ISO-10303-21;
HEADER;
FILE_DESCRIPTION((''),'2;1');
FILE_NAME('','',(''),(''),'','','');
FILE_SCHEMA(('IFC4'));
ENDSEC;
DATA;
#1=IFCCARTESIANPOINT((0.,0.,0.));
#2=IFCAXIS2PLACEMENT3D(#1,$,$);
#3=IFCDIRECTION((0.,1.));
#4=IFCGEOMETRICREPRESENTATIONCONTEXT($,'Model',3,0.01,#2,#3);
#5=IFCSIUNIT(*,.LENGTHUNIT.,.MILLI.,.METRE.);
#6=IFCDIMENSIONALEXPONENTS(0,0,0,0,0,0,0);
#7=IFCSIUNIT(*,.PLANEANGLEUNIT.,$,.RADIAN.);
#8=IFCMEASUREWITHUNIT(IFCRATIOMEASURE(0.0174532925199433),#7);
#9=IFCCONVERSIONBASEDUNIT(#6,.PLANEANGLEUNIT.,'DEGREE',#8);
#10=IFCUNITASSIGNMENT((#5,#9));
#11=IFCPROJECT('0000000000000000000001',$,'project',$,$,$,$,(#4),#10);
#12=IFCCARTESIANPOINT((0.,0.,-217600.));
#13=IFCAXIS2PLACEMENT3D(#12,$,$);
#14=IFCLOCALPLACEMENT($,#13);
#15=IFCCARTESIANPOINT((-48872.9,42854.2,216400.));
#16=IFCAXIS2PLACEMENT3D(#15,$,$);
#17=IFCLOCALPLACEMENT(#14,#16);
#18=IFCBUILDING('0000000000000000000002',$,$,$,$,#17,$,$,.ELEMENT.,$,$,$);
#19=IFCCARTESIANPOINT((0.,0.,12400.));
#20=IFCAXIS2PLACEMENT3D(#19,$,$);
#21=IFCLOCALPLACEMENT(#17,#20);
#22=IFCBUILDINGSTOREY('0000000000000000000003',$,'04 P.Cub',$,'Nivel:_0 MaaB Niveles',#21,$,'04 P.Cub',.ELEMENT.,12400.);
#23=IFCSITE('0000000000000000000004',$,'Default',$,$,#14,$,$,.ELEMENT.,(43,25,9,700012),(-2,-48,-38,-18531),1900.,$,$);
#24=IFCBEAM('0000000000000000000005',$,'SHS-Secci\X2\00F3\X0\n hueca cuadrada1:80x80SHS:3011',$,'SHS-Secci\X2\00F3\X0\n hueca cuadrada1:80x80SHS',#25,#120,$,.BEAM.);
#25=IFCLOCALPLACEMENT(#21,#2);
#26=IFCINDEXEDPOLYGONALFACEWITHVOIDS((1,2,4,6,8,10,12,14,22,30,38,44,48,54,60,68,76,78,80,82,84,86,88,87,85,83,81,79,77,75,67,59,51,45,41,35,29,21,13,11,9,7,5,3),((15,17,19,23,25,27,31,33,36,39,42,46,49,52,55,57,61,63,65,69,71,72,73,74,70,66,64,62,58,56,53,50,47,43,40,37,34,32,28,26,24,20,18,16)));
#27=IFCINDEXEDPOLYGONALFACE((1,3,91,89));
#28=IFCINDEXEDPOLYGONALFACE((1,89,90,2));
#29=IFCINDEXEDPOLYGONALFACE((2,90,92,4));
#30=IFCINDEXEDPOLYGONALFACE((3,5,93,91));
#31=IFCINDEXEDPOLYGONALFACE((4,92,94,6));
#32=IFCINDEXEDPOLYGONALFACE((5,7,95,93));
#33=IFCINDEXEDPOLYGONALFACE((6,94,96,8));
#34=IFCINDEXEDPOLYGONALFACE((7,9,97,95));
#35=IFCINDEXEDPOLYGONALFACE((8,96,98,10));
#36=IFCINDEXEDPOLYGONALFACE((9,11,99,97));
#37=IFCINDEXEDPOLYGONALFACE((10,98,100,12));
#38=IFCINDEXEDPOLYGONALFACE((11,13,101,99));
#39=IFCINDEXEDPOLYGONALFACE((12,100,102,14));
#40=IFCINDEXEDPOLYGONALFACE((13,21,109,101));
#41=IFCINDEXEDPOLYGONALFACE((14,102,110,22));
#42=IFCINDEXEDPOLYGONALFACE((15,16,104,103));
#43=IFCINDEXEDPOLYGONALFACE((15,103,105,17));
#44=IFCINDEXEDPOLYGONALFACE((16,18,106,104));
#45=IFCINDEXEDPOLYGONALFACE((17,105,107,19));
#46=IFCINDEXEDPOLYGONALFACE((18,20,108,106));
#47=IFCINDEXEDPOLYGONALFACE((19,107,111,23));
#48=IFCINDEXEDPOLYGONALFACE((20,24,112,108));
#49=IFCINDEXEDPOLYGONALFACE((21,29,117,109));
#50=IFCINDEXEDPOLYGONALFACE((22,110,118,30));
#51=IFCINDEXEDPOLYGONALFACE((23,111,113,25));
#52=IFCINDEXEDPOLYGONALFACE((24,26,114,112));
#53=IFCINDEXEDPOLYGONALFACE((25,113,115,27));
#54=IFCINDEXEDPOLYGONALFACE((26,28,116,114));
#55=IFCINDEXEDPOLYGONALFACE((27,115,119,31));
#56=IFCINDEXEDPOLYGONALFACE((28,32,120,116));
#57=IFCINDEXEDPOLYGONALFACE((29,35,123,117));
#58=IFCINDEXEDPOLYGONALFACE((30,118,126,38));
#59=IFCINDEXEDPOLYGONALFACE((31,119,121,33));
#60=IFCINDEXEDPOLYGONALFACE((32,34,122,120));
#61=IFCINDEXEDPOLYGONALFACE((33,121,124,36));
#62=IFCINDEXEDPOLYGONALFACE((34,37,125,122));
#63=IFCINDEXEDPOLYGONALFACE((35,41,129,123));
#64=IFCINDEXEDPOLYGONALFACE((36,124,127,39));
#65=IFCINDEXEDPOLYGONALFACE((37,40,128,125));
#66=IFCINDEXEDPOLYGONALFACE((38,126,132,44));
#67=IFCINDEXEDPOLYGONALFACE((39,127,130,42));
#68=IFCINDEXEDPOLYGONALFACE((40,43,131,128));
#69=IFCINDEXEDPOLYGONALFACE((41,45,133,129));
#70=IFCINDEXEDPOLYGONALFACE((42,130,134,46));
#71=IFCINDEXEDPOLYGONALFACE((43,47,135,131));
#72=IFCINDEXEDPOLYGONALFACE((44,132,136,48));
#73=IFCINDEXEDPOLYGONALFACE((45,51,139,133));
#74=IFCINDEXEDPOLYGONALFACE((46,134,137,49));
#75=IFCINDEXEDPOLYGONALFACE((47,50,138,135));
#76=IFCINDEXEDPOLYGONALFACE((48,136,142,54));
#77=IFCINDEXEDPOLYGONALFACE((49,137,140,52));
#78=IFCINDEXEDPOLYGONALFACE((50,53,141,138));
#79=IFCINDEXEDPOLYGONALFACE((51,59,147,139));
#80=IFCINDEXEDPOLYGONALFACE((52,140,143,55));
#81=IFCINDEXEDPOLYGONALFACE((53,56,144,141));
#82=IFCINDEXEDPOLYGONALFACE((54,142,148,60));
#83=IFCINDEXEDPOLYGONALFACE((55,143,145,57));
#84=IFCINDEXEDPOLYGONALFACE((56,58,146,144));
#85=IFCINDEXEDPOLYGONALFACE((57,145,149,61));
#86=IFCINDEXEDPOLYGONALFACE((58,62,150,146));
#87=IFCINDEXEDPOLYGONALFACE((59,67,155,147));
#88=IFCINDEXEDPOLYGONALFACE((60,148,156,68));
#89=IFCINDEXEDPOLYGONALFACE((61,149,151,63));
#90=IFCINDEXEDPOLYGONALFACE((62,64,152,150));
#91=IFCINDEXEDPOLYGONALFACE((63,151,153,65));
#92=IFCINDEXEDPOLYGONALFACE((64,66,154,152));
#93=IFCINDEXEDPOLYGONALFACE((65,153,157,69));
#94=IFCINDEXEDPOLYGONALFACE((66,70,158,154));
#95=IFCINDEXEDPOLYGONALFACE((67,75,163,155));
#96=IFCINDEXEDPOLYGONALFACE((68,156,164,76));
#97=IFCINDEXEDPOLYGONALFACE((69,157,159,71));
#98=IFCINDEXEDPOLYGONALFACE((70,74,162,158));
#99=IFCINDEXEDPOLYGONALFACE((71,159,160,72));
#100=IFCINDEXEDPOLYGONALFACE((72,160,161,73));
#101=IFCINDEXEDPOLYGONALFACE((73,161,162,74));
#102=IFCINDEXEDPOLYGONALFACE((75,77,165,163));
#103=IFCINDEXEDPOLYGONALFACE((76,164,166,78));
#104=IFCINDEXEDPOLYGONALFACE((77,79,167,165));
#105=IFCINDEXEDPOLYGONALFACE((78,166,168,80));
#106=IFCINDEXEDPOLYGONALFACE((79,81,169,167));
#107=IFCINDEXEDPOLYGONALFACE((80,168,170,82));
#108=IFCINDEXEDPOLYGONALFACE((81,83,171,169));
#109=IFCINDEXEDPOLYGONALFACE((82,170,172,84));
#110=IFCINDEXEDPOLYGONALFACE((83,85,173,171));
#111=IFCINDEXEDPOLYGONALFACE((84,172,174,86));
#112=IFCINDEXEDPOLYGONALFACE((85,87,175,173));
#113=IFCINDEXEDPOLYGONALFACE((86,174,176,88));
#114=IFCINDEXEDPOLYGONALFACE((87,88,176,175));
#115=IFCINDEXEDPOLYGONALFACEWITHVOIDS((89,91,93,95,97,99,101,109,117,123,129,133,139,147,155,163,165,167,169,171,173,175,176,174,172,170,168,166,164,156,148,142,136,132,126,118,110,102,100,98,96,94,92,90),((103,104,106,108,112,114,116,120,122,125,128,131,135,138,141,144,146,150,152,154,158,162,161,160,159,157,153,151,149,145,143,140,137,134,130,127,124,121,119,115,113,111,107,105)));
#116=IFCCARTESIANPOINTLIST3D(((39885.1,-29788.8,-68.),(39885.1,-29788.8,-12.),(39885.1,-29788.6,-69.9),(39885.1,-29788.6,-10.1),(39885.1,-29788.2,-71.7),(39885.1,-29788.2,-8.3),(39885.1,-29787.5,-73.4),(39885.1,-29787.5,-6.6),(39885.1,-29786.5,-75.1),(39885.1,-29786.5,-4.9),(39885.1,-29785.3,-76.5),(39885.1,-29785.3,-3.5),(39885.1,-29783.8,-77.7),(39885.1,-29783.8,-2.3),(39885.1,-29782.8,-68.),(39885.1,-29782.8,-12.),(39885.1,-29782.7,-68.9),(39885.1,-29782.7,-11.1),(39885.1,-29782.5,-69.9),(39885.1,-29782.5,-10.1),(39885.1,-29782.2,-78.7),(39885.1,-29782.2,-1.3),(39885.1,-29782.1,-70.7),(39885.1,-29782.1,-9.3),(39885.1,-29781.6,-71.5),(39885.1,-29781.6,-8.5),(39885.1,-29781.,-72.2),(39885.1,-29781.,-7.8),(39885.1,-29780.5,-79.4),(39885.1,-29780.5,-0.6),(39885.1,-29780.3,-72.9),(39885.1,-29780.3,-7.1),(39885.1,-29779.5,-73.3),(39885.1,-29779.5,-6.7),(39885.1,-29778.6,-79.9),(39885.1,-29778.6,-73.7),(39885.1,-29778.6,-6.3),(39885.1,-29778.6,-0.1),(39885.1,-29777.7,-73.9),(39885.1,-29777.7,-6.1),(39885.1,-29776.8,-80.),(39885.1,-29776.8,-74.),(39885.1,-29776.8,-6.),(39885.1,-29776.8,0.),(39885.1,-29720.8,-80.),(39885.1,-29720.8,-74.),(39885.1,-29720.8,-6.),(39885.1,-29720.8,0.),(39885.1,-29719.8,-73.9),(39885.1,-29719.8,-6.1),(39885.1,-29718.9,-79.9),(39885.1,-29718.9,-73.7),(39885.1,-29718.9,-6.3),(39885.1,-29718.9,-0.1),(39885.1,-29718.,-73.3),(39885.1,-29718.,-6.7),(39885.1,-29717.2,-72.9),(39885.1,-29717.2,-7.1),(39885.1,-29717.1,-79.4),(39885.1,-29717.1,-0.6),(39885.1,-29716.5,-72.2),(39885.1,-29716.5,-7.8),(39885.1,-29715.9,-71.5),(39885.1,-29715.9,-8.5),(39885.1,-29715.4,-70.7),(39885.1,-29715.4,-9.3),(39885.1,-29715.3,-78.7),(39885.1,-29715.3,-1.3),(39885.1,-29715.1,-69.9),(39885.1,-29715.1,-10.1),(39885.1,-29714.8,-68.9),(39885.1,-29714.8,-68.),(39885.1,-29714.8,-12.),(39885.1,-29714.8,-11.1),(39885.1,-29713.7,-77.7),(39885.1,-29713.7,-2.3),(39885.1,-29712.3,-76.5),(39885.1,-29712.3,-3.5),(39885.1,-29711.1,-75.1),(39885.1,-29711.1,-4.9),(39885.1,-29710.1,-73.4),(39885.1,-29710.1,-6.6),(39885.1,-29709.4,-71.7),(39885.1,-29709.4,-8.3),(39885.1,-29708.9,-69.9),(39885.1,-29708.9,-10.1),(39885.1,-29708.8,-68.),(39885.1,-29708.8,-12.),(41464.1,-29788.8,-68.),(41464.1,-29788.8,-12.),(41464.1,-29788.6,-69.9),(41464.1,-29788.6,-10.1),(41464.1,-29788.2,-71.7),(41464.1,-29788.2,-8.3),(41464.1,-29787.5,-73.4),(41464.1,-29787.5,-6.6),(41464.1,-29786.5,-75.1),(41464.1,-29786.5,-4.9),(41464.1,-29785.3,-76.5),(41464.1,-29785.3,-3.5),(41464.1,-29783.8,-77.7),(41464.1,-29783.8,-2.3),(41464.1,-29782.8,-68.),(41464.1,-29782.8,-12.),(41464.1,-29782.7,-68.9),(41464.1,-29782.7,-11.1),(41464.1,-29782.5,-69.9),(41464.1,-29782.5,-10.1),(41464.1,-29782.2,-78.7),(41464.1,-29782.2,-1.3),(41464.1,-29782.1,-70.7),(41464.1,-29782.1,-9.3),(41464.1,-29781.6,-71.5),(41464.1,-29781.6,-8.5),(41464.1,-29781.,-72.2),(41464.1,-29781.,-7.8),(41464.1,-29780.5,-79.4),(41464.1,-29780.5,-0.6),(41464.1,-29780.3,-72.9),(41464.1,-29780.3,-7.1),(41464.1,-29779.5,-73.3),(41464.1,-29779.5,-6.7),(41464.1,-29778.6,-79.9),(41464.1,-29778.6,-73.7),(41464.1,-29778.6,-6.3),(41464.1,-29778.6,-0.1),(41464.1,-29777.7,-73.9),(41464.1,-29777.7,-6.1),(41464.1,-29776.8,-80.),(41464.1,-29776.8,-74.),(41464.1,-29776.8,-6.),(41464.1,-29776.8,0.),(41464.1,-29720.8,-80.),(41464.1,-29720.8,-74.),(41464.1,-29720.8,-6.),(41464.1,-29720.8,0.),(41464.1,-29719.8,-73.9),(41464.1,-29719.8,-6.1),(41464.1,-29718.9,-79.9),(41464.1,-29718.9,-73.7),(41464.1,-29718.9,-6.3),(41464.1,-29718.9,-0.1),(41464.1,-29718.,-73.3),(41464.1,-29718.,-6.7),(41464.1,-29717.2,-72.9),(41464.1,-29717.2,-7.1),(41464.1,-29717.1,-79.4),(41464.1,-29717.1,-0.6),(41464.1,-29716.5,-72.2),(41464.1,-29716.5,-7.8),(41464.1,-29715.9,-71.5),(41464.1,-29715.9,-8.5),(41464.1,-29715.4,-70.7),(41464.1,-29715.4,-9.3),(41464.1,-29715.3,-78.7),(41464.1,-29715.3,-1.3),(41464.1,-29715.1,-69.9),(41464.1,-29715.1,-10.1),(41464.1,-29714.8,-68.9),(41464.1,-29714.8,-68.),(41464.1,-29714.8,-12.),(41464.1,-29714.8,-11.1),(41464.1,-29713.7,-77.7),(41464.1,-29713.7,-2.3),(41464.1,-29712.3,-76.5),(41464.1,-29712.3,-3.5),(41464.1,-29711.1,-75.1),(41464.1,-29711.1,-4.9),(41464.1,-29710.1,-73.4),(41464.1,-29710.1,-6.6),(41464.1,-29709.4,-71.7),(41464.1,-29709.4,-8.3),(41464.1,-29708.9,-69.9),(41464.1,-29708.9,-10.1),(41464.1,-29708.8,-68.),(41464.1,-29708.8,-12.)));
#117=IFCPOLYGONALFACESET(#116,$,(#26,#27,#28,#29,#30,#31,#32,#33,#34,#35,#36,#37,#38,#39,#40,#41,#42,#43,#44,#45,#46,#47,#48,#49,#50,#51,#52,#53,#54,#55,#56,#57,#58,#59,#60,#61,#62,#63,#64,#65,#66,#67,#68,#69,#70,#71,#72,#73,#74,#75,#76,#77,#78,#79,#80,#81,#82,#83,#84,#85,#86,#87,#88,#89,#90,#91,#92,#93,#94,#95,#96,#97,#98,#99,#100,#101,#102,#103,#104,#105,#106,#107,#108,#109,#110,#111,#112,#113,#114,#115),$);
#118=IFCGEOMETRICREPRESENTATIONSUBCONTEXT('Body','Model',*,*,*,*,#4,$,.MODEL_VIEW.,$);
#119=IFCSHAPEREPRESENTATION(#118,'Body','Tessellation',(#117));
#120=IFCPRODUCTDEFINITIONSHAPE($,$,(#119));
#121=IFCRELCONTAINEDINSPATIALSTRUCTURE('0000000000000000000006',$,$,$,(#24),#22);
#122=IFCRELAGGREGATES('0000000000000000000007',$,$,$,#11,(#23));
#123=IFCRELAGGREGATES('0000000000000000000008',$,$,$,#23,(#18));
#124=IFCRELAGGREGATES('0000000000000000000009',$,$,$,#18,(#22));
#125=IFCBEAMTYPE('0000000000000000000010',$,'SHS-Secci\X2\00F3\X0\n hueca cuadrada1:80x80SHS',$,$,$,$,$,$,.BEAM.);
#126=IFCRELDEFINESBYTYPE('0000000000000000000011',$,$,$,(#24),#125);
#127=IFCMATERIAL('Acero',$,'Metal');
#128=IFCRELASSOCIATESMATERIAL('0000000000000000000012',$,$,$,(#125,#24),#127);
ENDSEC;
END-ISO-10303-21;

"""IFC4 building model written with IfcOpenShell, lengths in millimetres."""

from ifc_helpers import new_model, entity, si_unit, converted_unit, direction, frame, origin, place, context, subcontext, project, spatial, indexed_curve, outline, extrude, source, transform, mapped, material, type_object, type_shapes, element, save


model = new_model("IFC4")

# Units and contexts
model_context = context("Model", 3, precision=0.01, world=origin(), true_north=direction((0.0, 1.0)))
body_context = subcontext(model_context, "Body", "Model", "MODEL_VIEW")
ifc_project = project(units=[si_unit("LENGTHUNIT", "METRE", prefix="MILLI"), converted_unit("PLANEANGLEUNIT", "DEGREE", entity("IfcRatioMeasure", 0.0174532925199433), si_unit("PLANEANGLEUNIT", "RADIAN"), dimensions=[0, 0, 0, 0, 0, 0, 0])], contexts=[model_context])

# Site, building, storey
site_placement = place(None, frame((0.0, 0.0, -217600.0)))
site = spatial("IfcSite", under=ifc_project, at=site_placement, Name="Default", CompositionType="ELEMENT", RefLatitude=(43, 25, 9, 700012), RefLongitude=(-2, -48, -38, -18531), RefElevation=1900.0)
building_placement = place(site_placement, frame((-48872.9, 42854.2, 216400.0)))
building = spatial("IfcBuilding", under=site, at=building_placement, CompositionType="ELEMENT")
storey_placement = place(building_placement, frame((0.0, 0.0, 12400.0)))
storey = spatial("IfcBuildingStorey", under=building, at=storey_placement, Name="04 P.Cub", ObjectType="Nivel:_0 MaaB Niveles", LongName="04 P.Cub", CompositionType="ELEMENT", Elevation=12400.0)

# Shared definitions
ifc_material_1 = material(Name="Acero", Category="Metal")

# Beam
beam_type_1 = type_object("IfcBeamType", Name="SHS-Sección hueca cuadrada1:80x80SHS", PredefinedType="BEAM", material=ifc_material_1)
shared_shape_1 = source(origin(), body_context, "Body", "SweptSolid", [
    extrude(outline(indexed_curve([(-40.0, -28.0), (-39.9, -29.9), (-39.4, -31.7), (-38.7, -33.4), (-37.7, -35.1), (-36.5, -36.5), (-35.1, -37.7), (-33.4, -38.7), (-31.7, -39.4), (-29.9, -39.9), (-28.0, -40.0), (28.0, -40.0), (29.9, -39.9), (31.7, -39.4), (33.4, -38.7), (35.1, -37.7), (36.5, -36.5), (37.7, -35.1), (38.7, -33.4), (39.4, -31.7), (39.9, -29.9), (40.0, -28.0), (40.0, 28.0), (39.9, 29.9), (39.4, 31.7), (38.7, 33.4), (37.7, 35.1), (36.5, 36.5), (35.1, 37.7), (33.4, 38.7), (31.7, 39.4), (29.9, 39.9), (28.0, 40.0), (-28.0, 40.0), (-29.9, 39.9), (-31.7, 39.4), (-33.4, 38.7), (-35.1, 37.7), (-36.5, 36.5), (-37.7, 35.1), (-38.7, 33.4), (-39.4, 31.7), (-39.9, 29.9), (-40.0, 28.0), (-40.0, -28.0)], self_intersect=False), holes=[indexed_curve([(28.0, -34.0), (-28.0, -34.0), (-28.9, -33.9), (-29.9, -33.7), (-30.7, -33.3), (-31.5, -32.9), (-32.2, -32.2), (-32.9, -31.5), (-33.3, -30.7), (-33.7, -29.9), (-33.9, -28.9), (-34.0, -28.0), (-34.0, 28.0), (-33.9, 28.9), (-33.7, 29.9), (-33.3, 30.7), (-32.9, 31.5), (-32.2, 32.2), (-31.5, 32.9), (-30.7, 33.3), (-29.9, 33.7), (-28.9, 33.9), (-28.0, 34.0), (28.0, 34.0), (28.9, 33.9), (29.9, 33.7), (30.7, 33.3), (31.5, 32.9), (32.2, 32.2), (32.9, 31.5), (33.3, 30.7), (33.7, 29.9), (33.9, 28.9), (34.0, 28.0), (34.0, -28.0), (33.9, -28.9), (33.7, -29.9), (33.3, -30.7), (32.9, -31.5), (32.2, -32.2), (31.5, -32.9), (30.7, -33.3), (29.9, -33.7), (28.9, -33.9), (28.0, -34.0)], self_intersect=False)]), frame((-733.0, 0.0, 0.0), z_axis=(1.0, 0.0, 0.0), x_axis=(0.0, -1.0, 0.0)), (0.0, 0.0, 1.0), 1579.0),
])
type_shapes(beam_type_1, [shared_shape_1])
beam_1_placement = place(storey_placement, frame((40731.1, -29748.8, -40.0), z_axis=(0.0, 0.0, 1.0), x_axis=(-1.0, 0.0, 0.0)))
element("IfcBeam", 1, at=beam_1_placement, inside=storey, type_object=beam_type_1, material=ifc_material_1, Name="SHS-Sección hueca cuadrada1:80x80SHS:3011", ObjectType="SHS-Sección hueca cuadrada1:80x80SHS", PredefinedType="BEAM", context=body_context, shape_type="MappedRepresentation", body=[
    mapped(shared_shape_1, transform((0.0, 0.0, 0.0), scale=1.0)),
])

save(model, "model.ifc")
